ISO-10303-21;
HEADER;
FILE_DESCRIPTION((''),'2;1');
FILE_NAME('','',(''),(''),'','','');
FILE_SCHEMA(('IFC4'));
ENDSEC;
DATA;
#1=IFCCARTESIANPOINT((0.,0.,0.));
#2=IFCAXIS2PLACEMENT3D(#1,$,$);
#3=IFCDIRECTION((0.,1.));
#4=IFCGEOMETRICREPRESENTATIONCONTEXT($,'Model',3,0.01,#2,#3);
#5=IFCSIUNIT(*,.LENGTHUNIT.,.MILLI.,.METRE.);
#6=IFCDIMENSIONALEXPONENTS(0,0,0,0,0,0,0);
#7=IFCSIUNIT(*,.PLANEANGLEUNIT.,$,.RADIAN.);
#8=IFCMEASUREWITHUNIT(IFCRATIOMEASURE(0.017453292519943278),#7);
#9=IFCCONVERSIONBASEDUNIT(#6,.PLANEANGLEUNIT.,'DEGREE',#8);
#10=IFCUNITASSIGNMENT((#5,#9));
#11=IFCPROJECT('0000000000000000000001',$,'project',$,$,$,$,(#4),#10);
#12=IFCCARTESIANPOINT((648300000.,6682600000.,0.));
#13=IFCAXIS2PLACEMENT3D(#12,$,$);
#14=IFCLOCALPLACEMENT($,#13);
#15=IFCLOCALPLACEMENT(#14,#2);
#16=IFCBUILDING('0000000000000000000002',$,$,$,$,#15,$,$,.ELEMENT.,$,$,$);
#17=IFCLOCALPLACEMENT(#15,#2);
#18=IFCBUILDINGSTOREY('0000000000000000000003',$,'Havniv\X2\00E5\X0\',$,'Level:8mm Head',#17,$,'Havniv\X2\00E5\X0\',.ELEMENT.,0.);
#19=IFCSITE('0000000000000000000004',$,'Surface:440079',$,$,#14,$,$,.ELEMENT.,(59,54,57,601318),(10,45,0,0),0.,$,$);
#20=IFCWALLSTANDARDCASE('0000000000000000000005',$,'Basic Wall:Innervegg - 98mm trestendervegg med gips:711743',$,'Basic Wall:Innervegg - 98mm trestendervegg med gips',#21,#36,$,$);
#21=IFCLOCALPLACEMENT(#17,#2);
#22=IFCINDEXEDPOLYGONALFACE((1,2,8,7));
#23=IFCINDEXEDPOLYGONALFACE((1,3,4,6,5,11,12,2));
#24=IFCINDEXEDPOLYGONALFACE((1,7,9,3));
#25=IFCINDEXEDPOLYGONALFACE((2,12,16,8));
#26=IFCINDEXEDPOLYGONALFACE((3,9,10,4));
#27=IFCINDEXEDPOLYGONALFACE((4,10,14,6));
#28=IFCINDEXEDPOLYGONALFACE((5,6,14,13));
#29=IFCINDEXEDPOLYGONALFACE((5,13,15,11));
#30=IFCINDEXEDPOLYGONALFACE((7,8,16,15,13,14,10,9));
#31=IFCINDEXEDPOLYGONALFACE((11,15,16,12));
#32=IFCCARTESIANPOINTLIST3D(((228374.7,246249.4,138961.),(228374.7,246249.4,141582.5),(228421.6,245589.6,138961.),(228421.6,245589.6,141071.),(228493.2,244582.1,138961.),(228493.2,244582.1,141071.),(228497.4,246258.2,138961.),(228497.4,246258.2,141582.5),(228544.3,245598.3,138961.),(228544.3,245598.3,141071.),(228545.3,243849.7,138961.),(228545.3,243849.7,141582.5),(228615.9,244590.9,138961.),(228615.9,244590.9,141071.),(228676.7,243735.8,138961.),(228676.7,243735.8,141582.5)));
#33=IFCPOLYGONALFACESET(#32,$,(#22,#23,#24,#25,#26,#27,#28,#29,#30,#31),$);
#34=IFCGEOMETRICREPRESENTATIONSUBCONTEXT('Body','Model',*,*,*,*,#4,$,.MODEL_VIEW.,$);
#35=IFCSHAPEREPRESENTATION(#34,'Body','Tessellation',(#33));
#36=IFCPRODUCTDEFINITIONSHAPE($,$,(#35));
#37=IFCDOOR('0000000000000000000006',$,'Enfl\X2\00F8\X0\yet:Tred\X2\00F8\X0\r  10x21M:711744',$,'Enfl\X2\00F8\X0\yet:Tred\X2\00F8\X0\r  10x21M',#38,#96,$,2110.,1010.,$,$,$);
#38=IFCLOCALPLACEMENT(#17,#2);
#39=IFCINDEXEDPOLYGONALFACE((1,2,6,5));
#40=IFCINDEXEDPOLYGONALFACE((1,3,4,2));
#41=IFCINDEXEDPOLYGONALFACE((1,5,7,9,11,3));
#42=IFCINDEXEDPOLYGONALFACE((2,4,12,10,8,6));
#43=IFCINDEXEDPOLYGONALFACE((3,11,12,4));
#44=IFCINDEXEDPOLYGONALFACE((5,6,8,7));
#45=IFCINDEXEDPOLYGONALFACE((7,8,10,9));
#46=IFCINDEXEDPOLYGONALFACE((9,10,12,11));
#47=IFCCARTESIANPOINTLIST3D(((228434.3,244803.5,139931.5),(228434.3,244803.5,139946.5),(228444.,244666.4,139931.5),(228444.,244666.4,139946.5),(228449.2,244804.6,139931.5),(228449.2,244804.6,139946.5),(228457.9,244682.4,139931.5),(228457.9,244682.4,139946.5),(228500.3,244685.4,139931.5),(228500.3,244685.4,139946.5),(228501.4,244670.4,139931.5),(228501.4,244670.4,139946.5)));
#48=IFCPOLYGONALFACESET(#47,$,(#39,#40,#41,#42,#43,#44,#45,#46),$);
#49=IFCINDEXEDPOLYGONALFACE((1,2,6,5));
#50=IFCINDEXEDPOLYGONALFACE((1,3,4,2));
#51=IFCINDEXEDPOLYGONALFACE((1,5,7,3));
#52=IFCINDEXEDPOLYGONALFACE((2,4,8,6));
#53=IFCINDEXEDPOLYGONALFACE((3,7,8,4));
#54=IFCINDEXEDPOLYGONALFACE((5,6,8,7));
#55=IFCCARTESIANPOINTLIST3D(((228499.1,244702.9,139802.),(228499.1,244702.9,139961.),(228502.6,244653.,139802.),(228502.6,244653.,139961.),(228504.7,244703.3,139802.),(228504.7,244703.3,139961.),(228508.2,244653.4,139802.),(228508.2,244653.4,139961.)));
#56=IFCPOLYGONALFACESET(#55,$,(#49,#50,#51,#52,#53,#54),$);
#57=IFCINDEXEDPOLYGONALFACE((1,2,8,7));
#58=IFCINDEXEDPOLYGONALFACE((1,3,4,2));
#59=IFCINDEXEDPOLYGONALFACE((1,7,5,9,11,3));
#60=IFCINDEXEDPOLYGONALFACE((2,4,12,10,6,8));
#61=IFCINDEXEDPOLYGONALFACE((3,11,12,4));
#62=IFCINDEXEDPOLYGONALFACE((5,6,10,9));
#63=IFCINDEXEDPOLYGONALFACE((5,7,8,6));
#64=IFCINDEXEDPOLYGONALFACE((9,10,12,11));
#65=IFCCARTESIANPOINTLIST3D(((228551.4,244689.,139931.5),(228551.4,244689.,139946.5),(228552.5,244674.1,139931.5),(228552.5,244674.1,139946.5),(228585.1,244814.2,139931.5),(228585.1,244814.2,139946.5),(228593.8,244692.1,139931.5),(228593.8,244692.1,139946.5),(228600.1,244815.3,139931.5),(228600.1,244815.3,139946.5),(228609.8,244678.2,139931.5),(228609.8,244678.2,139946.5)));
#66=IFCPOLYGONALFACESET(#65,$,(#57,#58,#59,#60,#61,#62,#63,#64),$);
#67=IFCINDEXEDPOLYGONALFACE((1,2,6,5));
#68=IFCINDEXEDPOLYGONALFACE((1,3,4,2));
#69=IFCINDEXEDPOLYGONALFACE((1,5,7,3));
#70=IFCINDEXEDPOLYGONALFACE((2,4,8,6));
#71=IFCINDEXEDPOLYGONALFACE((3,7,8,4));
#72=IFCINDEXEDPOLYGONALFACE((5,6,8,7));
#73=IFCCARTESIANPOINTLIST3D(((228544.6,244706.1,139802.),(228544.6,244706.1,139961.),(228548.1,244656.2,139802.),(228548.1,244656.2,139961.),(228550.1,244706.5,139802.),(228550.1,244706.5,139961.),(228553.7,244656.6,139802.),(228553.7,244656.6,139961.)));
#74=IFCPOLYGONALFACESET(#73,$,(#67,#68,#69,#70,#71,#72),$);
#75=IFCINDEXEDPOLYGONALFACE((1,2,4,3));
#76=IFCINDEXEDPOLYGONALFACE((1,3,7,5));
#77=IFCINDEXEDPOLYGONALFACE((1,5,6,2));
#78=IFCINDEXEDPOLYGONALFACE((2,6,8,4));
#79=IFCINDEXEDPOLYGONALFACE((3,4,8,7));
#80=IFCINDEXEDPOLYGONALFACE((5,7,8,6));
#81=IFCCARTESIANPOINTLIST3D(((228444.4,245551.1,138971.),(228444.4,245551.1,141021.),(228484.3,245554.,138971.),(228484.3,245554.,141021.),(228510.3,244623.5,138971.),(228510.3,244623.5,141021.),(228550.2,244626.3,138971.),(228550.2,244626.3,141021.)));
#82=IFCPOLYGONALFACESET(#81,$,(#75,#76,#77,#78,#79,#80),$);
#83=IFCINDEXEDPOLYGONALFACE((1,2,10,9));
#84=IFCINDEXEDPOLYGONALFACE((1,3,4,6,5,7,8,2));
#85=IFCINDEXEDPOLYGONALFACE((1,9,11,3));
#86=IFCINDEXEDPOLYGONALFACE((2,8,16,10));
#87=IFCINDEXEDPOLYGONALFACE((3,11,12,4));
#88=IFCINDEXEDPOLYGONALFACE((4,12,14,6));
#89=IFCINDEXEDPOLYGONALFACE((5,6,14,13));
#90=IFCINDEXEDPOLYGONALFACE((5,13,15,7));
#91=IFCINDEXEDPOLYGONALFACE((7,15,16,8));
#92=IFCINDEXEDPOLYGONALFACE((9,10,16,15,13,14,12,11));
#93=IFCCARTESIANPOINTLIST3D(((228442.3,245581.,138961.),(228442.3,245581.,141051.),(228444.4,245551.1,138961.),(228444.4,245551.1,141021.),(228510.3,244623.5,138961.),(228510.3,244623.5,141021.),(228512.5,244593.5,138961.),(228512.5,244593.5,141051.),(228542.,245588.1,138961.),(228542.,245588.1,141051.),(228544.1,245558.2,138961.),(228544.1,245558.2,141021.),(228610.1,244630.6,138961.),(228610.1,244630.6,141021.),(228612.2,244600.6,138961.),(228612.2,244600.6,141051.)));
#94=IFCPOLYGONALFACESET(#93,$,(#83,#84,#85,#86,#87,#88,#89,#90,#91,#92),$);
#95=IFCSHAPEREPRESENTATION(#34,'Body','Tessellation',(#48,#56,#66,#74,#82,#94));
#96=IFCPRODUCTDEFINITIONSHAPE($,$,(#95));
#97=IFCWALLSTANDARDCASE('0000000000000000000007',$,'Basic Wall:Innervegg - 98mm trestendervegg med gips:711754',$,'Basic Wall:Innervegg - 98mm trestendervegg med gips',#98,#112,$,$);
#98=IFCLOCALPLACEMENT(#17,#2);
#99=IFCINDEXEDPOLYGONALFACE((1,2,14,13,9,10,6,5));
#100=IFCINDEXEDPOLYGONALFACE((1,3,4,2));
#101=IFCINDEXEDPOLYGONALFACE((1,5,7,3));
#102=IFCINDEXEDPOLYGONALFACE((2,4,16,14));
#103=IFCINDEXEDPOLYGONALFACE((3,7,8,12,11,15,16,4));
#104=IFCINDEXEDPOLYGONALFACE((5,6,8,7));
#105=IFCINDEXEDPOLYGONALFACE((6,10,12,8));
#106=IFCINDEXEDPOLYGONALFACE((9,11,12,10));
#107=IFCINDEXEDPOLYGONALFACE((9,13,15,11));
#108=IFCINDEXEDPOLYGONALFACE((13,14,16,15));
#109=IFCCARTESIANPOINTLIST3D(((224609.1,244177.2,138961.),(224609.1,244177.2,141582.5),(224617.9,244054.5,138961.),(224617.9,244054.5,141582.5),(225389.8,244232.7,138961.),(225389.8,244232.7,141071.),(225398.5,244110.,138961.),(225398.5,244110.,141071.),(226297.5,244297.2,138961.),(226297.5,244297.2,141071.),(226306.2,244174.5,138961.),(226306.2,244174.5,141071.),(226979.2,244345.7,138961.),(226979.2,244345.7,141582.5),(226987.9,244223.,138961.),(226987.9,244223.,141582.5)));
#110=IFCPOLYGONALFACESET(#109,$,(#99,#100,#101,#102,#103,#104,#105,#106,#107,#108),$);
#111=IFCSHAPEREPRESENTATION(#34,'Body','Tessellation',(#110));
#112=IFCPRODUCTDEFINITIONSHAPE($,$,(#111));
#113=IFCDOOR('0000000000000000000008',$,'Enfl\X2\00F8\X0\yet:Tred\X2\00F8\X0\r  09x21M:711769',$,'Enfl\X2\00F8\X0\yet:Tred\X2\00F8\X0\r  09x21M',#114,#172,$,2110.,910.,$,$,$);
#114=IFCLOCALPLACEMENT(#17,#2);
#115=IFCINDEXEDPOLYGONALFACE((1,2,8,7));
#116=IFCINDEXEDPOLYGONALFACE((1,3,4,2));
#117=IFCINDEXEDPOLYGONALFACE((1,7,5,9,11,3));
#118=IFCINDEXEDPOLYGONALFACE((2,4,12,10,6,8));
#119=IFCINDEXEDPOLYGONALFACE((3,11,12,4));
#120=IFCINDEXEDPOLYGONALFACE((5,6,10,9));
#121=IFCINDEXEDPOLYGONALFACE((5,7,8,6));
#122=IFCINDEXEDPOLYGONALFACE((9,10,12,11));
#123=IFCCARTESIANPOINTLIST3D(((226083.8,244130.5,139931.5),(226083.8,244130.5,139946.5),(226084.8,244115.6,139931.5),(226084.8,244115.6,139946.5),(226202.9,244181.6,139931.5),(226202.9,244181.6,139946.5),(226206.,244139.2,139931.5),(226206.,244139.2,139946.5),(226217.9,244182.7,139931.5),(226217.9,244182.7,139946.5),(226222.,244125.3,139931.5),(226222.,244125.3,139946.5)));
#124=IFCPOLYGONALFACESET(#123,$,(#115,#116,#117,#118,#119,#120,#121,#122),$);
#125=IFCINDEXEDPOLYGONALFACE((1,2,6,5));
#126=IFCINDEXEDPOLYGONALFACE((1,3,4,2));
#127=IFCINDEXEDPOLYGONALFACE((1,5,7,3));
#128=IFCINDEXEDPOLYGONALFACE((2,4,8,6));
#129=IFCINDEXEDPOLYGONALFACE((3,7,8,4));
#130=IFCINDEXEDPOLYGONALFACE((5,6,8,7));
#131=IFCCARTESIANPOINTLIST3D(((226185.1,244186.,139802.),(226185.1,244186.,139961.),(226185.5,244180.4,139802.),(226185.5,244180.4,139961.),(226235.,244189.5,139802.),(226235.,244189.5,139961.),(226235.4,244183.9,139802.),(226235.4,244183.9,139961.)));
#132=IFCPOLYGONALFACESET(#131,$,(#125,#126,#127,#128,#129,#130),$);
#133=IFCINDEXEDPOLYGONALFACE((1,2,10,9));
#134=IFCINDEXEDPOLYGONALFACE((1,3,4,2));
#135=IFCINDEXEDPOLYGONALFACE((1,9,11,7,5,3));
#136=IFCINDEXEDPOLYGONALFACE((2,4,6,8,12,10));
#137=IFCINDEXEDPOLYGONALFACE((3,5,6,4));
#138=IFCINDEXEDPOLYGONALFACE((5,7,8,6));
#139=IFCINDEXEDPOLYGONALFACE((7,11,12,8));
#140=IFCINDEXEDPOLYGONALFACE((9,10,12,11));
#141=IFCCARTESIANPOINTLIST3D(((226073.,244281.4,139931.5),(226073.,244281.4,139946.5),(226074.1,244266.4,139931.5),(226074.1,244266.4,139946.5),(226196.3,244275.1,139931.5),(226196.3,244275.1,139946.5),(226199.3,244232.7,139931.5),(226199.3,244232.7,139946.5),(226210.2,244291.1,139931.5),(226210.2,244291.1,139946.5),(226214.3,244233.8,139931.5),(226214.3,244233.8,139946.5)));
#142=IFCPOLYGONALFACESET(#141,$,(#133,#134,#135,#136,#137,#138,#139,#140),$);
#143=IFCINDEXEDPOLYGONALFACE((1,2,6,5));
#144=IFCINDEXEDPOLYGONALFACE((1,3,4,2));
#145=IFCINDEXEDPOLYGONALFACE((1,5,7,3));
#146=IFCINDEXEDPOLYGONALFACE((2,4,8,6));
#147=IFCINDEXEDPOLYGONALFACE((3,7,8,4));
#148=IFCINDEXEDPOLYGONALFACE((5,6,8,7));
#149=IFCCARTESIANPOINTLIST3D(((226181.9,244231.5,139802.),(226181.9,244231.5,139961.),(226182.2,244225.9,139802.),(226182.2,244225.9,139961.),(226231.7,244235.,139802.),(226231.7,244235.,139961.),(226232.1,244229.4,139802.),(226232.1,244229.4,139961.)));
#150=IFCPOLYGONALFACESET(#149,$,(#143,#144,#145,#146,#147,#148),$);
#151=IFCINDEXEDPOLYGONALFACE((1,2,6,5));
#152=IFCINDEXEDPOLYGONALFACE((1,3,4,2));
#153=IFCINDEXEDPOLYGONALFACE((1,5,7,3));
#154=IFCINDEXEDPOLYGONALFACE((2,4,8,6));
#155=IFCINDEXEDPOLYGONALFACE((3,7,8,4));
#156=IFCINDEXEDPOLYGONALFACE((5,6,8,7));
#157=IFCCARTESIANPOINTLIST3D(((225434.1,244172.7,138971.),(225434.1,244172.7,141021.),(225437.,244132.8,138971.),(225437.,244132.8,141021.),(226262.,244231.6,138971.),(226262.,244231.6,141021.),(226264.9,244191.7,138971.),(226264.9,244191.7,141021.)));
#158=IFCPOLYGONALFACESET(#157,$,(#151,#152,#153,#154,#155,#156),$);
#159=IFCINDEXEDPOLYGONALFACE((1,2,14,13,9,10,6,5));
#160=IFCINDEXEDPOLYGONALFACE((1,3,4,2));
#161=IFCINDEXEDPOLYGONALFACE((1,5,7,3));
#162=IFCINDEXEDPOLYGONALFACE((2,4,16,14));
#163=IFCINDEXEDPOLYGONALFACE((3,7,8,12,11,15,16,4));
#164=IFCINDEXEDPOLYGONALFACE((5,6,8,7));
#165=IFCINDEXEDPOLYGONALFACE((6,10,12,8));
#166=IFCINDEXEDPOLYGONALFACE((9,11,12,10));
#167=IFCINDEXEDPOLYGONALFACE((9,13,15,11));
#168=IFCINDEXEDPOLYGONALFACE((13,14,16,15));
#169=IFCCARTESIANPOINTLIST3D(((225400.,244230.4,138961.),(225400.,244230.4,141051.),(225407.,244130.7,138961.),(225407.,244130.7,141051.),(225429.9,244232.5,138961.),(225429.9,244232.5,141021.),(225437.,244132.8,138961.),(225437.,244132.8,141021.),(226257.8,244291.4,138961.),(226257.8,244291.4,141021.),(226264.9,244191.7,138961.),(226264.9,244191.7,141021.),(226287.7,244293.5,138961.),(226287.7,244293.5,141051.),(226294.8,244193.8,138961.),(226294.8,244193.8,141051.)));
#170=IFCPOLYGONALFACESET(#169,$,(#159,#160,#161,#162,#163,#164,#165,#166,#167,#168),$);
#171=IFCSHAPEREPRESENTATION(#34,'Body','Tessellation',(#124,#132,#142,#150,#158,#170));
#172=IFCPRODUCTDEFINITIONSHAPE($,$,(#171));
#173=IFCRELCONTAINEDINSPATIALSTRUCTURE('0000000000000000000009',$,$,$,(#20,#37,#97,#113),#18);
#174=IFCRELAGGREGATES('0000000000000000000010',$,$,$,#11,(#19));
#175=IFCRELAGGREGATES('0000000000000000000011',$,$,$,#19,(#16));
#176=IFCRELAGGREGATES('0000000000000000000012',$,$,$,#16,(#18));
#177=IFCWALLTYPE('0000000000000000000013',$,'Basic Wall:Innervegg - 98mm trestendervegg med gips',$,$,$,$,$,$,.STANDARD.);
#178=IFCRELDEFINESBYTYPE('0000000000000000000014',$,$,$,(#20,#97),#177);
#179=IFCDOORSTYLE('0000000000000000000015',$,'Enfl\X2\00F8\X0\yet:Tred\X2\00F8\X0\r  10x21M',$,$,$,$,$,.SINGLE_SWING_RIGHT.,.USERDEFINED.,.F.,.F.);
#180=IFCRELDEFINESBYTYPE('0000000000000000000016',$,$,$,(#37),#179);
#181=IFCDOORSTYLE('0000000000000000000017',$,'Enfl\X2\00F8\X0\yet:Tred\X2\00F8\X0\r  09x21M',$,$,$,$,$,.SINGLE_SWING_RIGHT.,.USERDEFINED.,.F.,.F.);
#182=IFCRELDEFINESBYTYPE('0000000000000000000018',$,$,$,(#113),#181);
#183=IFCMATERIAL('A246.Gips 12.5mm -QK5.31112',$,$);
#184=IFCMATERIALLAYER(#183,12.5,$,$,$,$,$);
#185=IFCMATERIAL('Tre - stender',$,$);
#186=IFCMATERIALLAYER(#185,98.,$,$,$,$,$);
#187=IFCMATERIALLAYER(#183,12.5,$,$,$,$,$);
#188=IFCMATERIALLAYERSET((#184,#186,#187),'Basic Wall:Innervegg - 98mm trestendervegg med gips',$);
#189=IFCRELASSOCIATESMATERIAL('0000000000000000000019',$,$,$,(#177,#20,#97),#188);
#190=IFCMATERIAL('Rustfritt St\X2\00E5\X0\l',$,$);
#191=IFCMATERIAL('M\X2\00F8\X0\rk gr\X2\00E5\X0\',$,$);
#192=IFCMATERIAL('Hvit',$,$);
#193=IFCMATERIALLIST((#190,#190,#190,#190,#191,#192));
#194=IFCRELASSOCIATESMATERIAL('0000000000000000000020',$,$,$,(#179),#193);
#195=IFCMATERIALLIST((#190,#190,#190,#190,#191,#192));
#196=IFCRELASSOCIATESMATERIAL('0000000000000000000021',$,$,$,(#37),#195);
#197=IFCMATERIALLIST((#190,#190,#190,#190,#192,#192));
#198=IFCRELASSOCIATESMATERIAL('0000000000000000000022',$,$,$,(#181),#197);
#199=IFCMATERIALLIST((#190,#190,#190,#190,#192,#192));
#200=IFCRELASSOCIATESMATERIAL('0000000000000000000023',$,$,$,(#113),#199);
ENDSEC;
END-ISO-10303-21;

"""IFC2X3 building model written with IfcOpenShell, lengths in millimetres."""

from ifc_helpers import new_model, entity, si_unit, converted_unit, direction, frame, frame_2d, origin, origin_2d_with_axis, place, context, subcontext, project, spatial, polyline, rectangle, outline, extrude, clip, bounded_halfspace, source, transform, mapped, material, material_list, layer, layer_set, layer_usage, type_object, type_shapes, element, fill, save


model = new_model("IFC2X3")

# Units and contexts
model_context = context("Model", 3, precision=0.01, world=origin(), true_north=direction((0.0, 1.0)))
body_context = subcontext(model_context, "Body", "Model", "MODEL_VIEW")
ifc_project = project(units=[si_unit("LENGTHUNIT", "METRE", prefix="MILLI"), converted_unit("PLANEANGLEUNIT", "DEGREE", entity("IfcRatioMeasure", 0.017453292519943278), si_unit("PLANEANGLEUNIT", "RADIAN"), dimensions=[0, 0, 0, 0, 0, 0, 0])], contexts=[model_context])

# Site, building, storey
site_placement = place(None, frame((648300000.0, 6682600000.0, 0.0)))
site = spatial("IfcSite", under=ifc_project, at=site_placement, Name="Surface:440079", CompositionType="ELEMENT", RefLatitude=(59, 54, 57, 601318), RefLongitude=(10, 45, 0, 0), RefElevation=0.0)
building_placement = place(site_placement, origin())
building = spatial("IfcBuilding", under=site, at=building_placement, CompositionType="ELEMENT")
storey_placement = place(building_placement, origin())
storey = spatial("IfcBuildingStorey", under=building, at=storey_placement, Name="Havnivå", ObjectType="Level:8mm Head", LongName="Havnivå", CompositionType="ELEMENT", Elevation=0.0)

# Walls, openings, doors
ifc_material_1 = material(Name="A246.Gips 12.5mm -QK5.31112")
ifc_layer_1 = layer(ifc_material_1, 12.5)
ifc_material_2 = material(Name="Tre - stender")
ifc_layer_2 = layer(ifc_material_2, 98.0)
ifc_layer_3 = layer(ifc_material_1, 12.5)
ifc_layer_set = layer_set([ifc_layer_1, ifc_layer_2, ifc_layer_3], Name="Basic Wall:Innervegg - 98mm trestendervegg med gips")
ifc_layer_usage_1 = layer_usage(ifc_layer_set, "AXIS2", "NEGATIVE", 61.5)
wall_type = type_object("IfcWallType", Name="Basic Wall:Innervegg - 98mm trestendervegg med gips", PredefinedType="STANDARD", material=ifc_layer_set)
wall_1_placement = place(storey_placement, frame((228436.0, 246253.8, 138961.0), z_axis=(0.0, 0.0, 1.0), x_axis=(0.070908, -0.997483, 0.0)))
wall_1 = element("IfcWallStandardCase", 1, at=wall_1_placement, inside=storey, type_object=wall_type, material=ifc_layer_usage_1, Name="Basic Wall:Innervegg - 98mm trestendervegg med gips:711743", ObjectType="Basic Wall:Innervegg - 98mm trestendervegg med gips", context=body_context, shape_type="Clipping", body=[
    clip(extrude(outline(polyline([(0.0, -61.5), (2405.8, -61.5), (2528.8, 61.5), (2354.8, 61.5), (0.0, 61.5), (0.0, -61.5)])), origin(), (0.0, 0.0, 1.0), 2621.5), bounded_halfspace(frame((0.0, -61.5, 2621.5), z_axis=(0.0, 0.0, -1.0), x_axis=(0.0, 1.0, 0.0)), True, frame((0.0, -61.5, 2621.5)), polyline([(0.0, 0.0), (733275.1, 0.0), (770765.5, 37490.4), (717746.0, 37490.4), (0.0, 37490.4), (0.0, 0.0)]))),
])
opening_1_placement = place(wall_1_placement, frame((1671.5, 61.5, 0.0)))
opening_1 = element("IfcOpeningElement", 2, at=opening_1_placement, cuts=wall_1, ObjectType="Opening", context=body_context, shape_type="SweptSolid", body=[
    extrude(rectangle(XDim=2110.0, YDim=1010.0, at=frame_2d((1055.0, 505.0), x_axis=(1.0, 0.0))), frame((0.0, 0.0, 0.0), z_axis=(0.0, -1.0, 0.0), x_axis=(0.0, 0.0, 1.0)), (0.0, 0.0, 1.0), 123.0),
])
ifc_material_3 = material(Name="Rustfritt Stål")
ifc_material_4 = material(Name="Mørk grå")
ifc_material_5 = material(Name="Hvit")
ifc_material_list_1 = material_list([ifc_material_3, ifc_material_3, ifc_material_3, ifc_material_3, ifc_material_4, ifc_material_5])
ifc_material_list_2 = material_list([ifc_material_3, ifc_material_3, ifc_material_3, ifc_material_3, ifc_material_4, ifc_material_5])
door_style_1 = type_object("IfcDoorStyle", Name="Enfløyet:Tredør  10x21M", ConstructionType="USERDEFINED", OperationType="SINGLE_SWING_RIGHT", ParameterTakesPrecedence=False, Sizeable=False, material=ifc_material_list_2)
shared_shape_1 = source(origin(), body_context, "Body", "SweptSolid", [
    extrude(outline(polyline([(-50.8, -33.3), (-35.8, -33.3), (-35.8, 9.2), (86.7, 9.2), (86.7, 24.2), (-50.8, 24.2), (-50.8, -33.3)])), frame((138.3, 141.9, 970.5)), (0.0, 0.0, 1.0), 15.0),
    extrude(rectangle(XDim=50.0, YDim=5.6, at=frame_2d((0.0, 0.0), x_axis=(1.0, 0.0))), frame((95.0, 105.8, 841.0), z_axis=(0.0, 0.0, 1.0), x_axis=(-1.0, 0.0, 0.0)), (0.0, 0.0, 1.0), 159.0),
    extrude(outline(polyline([(-33.3, -50.8), (24.2, -50.8), (24.2, 86.7), (9.2, 86.7), (9.2, -35.8), (-33.3, -35.8), (-33.3, -50.8)])), frame((138.3, 24.1, 970.5), z_axis=(0.0, 0.0, 1.0), x_axis=(0.0, -1.0, 0.0)), (0.0, 0.0, 1.0), 15.0),
    extrude(rectangle(XDim=5.6, YDim=50.0, at=frame_2d((0.0, 0.0), x_axis=(1.0, 0.0))), frame((95.0, 60.2, 841.0), z_axis=(0.0, 0.0, 1.0), x_axis=(0.0, 1.0, 0.0)), (0.0, 0.0, 1.0), 159.0),
    extrude(rectangle(XDim=40.0, YDim=930.0, at=origin_2d_with_axis()), frame((505.0, 83.0, 10.0), z_axis=(0.0, 0.0, 1.0), x_axis=(0.0, -1.0, 0.0)), (0.0, 0.0, 1.0), 2050.0),
    extrude(outline(polyline([(-1037.5, -495.0), (1052.5, -495.0), (1052.5, 495.0), (-1037.5, 495.0), (-1037.5, 465.0), (1022.5, 465.0), (1022.5, -465.0), (-1037.5, -465.0), (-1037.5, -495.0)])), frame((505.0, 3.0, 1037.5), z_axis=(0.0, 1.0, 0.0), x_axis=(0.0, 0.0, 1.0)), (0.0, 0.0, 1.0), 100.0),
])
type_shapes(door_style_1, [shared_shape_1])
door_1_placement = place(opening_1_placement, frame((0.0, 0.0, 0.0), z_axis=(0.0, 0.0, 1.0), x_axis=(-1.0, 0.0, 0.0)))
door_1 = element("IfcDoor", 3, at=door_1_placement, inside=storey, type_object=door_style_1, material=ifc_material_list_1, Name="Enfløyet:Tredør  10x21M:711744", ObjectType="Enfløyet:Tredør  10x21M", OverallHeight=2110.0, OverallWidth=1010.0, context=body_context, shape_type="MappedRepresentation", body=[
    mapped(shared_shape_1, transform((0.0, 0.0, 0.0), scale=1.0)),
])
fill(opening_1, door_1)
ifc_layer_usage_2 = layer_usage(ifc_layer_set, "AXIS2", "NEGATIVE", 61.5)
wall_2_placement = place(storey_placement, frame((226983.5, 244284.3, 138961.0), z_axis=(0.0, 0.0, 1.0), x_axis=(-0.997483, -0.070908, 0.0)))
wall_2 = element("IfcWallStandardCase", 4, at=wall_2_placement, inside=storey, type_object=wall_type, material=ifc_layer_usage_2, Name="Basic Wall:Innervegg - 98mm trestendervegg med gips:711754", ObjectType="Basic Wall:Innervegg - 98mm trestendervegg med gips", context=body_context, shape_type="Clipping", body=[
    clip(extrude(rectangle(XDim=2376.0, YDim=123.0, at=frame_2d((1188.0, 0.0), x_axis=(1.0, 0.0))), origin(), (0.0, 0.0, 1.0), 2621.5), bounded_halfspace(frame((0.0, -61.5, 2621.5), z_axis=(0.0, 0.0, -1.0), x_axis=(-1.0, 0.0, 0.0)), True, frame((0.0, -61.5, 2621.5)), polyline([(0.0, 0.0), (37490.4, 0.0), (724204.8, 0.0), (724204.8, 37490.4), (0.0, 37490.4), (0.0, 0.0)]))),
])
opening_2_placement = place(wall_2_placement, frame((683.4, -61.5, 0.0)))
opening_2 = element("IfcOpeningElement", 5, at=opening_2_placement, cuts=wall_2, ObjectType="Opening", context=body_context, shape_type="SweptSolid", body=[
    extrude(rectangle(XDim=2110.0, YDim=910.0, at=frame_2d((1055.0, 455.0), x_axis=(1.0, 0.0))), frame((0.0, 0.0, 0.0), z_axis=(0.0, 1.0, 0.0), x_axis=(0.0, 0.0, 1.0)), (0.0, 0.0, 1.0), 123.0),
])
ifc_material_list_3 = material_list([ifc_material_3, ifc_material_3, ifc_material_3, ifc_material_3, ifc_material_5, ifc_material_5])
ifc_material_list_4 = material_list([ifc_material_3, ifc_material_3, ifc_material_3, ifc_material_3, ifc_material_5, ifc_material_5])
door_style_2 = type_object("IfcDoorStyle", Name="Enfløyet:Tredør  09x21M", ConstructionType="USERDEFINED", OperationType="SINGLE_SWING_RIGHT", ParameterTakesPrecedence=False, Sizeable=False, material=ifc_material_list_4)
shared_shape_2 = source(origin(), body_context, "Body", "SweptSolid", [
    extrude(outline(polyline([(-50.8, -33.3), (-35.8, -33.3), (-35.8, 9.2), (86.7, 9.2), (86.7, 24.2), (-50.8, 24.2), (-50.8, -33.3)])), frame((138.3, 141.9, 970.5)), (0.0, 0.0, 1.0), 15.0),
    extrude(rectangle(XDim=50.0, YDim=5.6, at=frame_2d((0.0, 0.0), x_axis=(1.0, 0.0))), frame((95.0, 105.8, 841.0), z_axis=(0.0, 0.0, 1.0), x_axis=(-1.0, 0.0, 0.0)), (0.0, 0.0, 1.0), 159.0),
    extrude(outline(polyline([(-33.3, -50.8), (24.2, -50.8), (24.2, 86.7), (9.2, 86.7), (9.2, -35.8), (-33.3, -35.8), (-33.3, -50.8)])), frame((138.3, 24.1, 970.5), z_axis=(0.0, 0.0, 1.0), x_axis=(0.0, -1.0, 0.0)), (0.0, 0.0, 1.0), 15.0),
    extrude(rectangle(XDim=5.6, YDim=50.0, at=frame_2d((0.0, 0.0), x_axis=(1.0, 0.0))), frame((95.0, 60.2, 841.0), z_axis=(0.0, 0.0, 1.0), x_axis=(0.0, 1.0, 0.0)), (0.0, 0.0, 1.0), 159.0),
    extrude(rectangle(XDim=40.0, YDim=830.0, at=origin_2d_with_axis()), frame((455.0, 83.0, 10.0), z_axis=(0.0, 0.0, 1.0), x_axis=(0.0, -1.0, 0.0)), (0.0, 0.0, 1.0), 2050.0),
    extrude(outline(polyline([(-1037.5, -445.0), (1052.5, -445.0), (1052.5, 445.0), (-1037.5, 445.0), (-1037.5, 415.0), (1022.5, 415.0), (1022.5, -415.0), (-1037.5, -415.0), (-1037.5, -445.0)])), frame((455.0, 3.0, 1037.5), z_axis=(0.0, 1.0, 0.0), x_axis=(0.0, 0.0, 1.0)), (0.0, 0.0, 1.0), 100.0),
])
type_shapes(door_style_2, [shared_shape_2])
door_2_placement = place(opening_2_placement, origin())
door_2 = element("IfcDoor", 6, at=door_2_placement, inside=storey, type_object=door_style_2, material=ifc_material_list_3, Name="Enfløyet:Tredør  09x21M:711769", ObjectType="Enfløyet:Tredør  09x21M", OverallHeight=2110.0, OverallWidth=910.0, context=body_context, shape_type="MappedRepresentation", body=[
    mapped(shared_shape_2, transform((0.0, 0.0, 0.0), scale=1.0)),
])
fill(opening_2, door_2)

save(model, "model.ifc")
